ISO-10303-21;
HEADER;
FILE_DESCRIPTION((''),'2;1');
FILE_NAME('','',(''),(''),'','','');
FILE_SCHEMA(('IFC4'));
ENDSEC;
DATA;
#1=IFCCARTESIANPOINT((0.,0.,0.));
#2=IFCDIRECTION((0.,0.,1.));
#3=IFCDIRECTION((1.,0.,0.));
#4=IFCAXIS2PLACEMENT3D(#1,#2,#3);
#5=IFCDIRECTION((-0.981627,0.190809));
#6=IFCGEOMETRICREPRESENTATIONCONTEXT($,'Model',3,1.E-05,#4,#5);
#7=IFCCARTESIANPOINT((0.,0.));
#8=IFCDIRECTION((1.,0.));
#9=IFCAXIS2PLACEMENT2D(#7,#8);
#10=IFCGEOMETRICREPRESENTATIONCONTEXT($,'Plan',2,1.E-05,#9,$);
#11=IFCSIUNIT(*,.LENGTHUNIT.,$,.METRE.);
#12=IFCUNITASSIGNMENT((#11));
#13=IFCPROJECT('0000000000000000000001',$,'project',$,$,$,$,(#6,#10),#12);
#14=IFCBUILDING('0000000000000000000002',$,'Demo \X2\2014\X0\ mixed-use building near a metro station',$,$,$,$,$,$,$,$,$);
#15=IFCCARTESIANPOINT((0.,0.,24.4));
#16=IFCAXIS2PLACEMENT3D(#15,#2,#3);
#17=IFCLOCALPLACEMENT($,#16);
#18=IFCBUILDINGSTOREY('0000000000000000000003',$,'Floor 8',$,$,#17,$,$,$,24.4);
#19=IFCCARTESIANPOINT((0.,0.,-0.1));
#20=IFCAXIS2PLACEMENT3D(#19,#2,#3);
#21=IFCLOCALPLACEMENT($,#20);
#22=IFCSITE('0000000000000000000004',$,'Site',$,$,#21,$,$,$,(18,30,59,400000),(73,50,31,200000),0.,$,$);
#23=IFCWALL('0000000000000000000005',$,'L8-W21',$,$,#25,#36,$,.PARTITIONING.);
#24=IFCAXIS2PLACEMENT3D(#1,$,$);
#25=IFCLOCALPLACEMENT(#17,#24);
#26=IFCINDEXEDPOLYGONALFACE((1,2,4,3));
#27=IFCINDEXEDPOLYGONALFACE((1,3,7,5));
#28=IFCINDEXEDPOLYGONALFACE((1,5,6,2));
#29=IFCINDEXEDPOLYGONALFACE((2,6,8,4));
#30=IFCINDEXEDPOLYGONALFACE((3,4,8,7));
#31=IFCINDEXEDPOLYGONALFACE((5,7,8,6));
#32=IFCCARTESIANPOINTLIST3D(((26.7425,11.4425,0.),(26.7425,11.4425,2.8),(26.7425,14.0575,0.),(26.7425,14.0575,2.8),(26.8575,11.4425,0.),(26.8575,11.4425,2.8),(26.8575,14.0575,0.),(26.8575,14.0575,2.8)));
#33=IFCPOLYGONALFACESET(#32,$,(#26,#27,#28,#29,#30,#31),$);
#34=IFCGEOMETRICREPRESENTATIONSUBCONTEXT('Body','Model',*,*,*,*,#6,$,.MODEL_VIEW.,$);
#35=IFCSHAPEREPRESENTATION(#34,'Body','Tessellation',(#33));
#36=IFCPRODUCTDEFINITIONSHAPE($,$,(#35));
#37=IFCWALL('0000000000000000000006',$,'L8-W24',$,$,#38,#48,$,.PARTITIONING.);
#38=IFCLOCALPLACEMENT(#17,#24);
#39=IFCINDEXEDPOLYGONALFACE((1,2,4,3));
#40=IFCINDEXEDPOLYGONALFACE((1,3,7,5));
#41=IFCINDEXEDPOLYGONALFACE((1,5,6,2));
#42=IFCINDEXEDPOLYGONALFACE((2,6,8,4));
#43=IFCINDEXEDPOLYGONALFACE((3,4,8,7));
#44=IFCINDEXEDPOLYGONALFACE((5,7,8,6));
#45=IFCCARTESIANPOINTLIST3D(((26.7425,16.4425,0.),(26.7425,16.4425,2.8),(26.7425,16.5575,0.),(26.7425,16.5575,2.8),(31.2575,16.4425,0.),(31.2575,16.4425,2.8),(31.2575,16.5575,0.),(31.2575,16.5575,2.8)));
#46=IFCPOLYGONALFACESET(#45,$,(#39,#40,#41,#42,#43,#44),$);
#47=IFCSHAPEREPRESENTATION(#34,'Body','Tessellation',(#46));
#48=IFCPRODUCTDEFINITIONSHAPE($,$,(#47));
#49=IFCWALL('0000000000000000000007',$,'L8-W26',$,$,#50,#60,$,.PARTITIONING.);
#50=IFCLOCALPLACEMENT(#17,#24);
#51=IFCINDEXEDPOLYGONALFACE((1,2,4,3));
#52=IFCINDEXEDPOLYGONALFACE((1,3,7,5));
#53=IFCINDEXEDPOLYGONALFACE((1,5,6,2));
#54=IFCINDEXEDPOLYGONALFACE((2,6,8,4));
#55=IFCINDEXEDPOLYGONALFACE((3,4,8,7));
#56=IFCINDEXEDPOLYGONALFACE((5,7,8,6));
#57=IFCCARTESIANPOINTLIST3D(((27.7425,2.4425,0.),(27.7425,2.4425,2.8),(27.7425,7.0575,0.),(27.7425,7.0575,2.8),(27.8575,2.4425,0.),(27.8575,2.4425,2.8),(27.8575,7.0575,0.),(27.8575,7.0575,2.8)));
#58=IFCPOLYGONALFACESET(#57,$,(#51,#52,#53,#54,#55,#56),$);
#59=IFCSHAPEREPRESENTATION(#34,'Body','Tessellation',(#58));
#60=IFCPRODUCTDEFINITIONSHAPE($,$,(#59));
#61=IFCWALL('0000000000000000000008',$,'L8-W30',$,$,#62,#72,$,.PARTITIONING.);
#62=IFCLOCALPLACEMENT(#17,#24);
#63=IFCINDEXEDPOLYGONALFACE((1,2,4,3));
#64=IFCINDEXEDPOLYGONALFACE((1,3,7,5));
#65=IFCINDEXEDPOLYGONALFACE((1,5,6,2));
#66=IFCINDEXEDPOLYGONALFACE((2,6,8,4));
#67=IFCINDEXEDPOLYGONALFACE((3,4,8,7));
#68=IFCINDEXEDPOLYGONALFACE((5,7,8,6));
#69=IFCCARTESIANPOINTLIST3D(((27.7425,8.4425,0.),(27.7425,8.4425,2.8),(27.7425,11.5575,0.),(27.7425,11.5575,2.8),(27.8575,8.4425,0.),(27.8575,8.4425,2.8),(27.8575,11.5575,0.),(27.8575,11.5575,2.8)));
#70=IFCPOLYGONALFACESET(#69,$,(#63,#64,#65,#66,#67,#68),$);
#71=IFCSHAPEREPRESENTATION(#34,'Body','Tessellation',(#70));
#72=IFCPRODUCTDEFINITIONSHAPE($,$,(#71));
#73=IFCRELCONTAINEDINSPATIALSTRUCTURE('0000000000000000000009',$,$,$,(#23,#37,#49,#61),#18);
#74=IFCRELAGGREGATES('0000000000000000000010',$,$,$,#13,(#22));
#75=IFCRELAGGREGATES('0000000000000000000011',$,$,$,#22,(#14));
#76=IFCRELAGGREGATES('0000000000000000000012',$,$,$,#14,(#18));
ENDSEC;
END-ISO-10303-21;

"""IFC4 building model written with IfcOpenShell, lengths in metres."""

from ifc_helpers import new_model, si_unit, direction, frame, origin_with_axes, origin_2d_with_axis, place, context, subcontext, project, spatial, line, indexed_curve, outline, extrude, element, save


model = new_model("IFC4")

# Units and contexts
model_context = context("Model", 3, precision=1e-05, world=origin_with_axes(), true_north=direction((-0.981627, 0.190809)))
plan_context = context("Plan", 2, precision=1e-05, world=origin_2d_with_axis())
body_context = subcontext(model_context, "Body", "Model", "MODEL_VIEW")
ifc_project = project(units=[si_unit("LENGTHUNIT", "METRE")], contexts=[model_context, plan_context])

# Site, building, storey
site_placement = place(None, frame((0.0, 0.0, -0.1), z_axis=(0.0, 0.0, 1.0), x_axis=(1.0, 0.0, 0.0)))
site = spatial("IfcSite", under=ifc_project, at=site_placement, Name="Site", RefLatitude=(18, 30, 59, 400000), RefLongitude=(73, 50, 31, 200000), RefElevation=0.0)
building = spatial("IfcBuilding", under=site, Name="Demo — mixed-use building near a metro station")
storey_placement = place(None, frame((0.0, 0.0, 24.4), z_axis=(0.0, 0.0, 1.0), x_axis=(1.0, 0.0, 0.0)))
storey = spatial("IfcBuildingStorey", under=building, at=storey_placement, Name="Floor 8", Elevation=24.4)

# Wall
wall_1_placement = place(storey_placement, frame((0.0, 0.0, -24.4), z_axis=(0.0, 0.0, 1.0), x_axis=(1.0, 0.0, 0.0)))
element("IfcWall", 1, at=wall_1_placement, inside=storey, Name="L8-W21", PredefinedType="PARTITIONING", context=body_context, shape_type="SweptSolid", body=[
    extrude(outline(indexed_curve([(26.7425, 11.4425), (26.7425, 14.0575), (26.8575, 14.0575), (26.8575, 11.4425)], segments=[line(1, 2, 3, 4, 1)])), frame((0.0, 0.0, 24.4), z_axis=(0.0, 0.0, 1.0), x_axis=(1.0, 0.0, 0.0)), (0.0, 0.0, 1.0), 2.8),
])

# Wall
wall_2_placement = place(storey_placement, frame((0.0, 0.0, -24.4), z_axis=(0.0, 0.0, 1.0), x_axis=(1.0, 0.0, 0.0)))
element("IfcWall", 2, at=wall_2_placement, inside=storey, Name="L8-W24", PredefinedType="PARTITIONING", context=body_context, shape_type="SweptSolid", body=[
    extrude(outline(indexed_curve([(31.2575, 16.4425), (26.7425, 16.4425), (26.7425, 16.5575), (31.2575, 16.5575)], segments=[line(1, 2, 3, 4, 1)])), frame((0.0, 0.0, 24.4), z_axis=(0.0, 0.0, 1.0), x_axis=(1.0, 0.0, 0.0)), (0.0, 0.0, 1.0), 2.8),
])

# Wall
wall_3_placement = place(storey_placement, frame((0.0, 0.0, -24.4), z_axis=(0.0, 0.0, 1.0), x_axis=(1.0, 0.0, 0.0)))
element("IfcWall", 3, at=wall_3_placement, inside=storey, Name="L8-W26", PredefinedType="PARTITIONING", context=body_context, shape_type="SweptSolid", body=[
    extrude(outline(indexed_curve([(27.7425, 2.4425), (27.7425, 7.0575), (27.8575, 7.0575), (27.8575, 2.4425)], segments=[line(1, 2, 3, 4, 1)])), frame((0.0, 0.0, 24.4), z_axis=(0.0, 0.0, 1.0), x_axis=(1.0, 0.0, 0.0)), (0.0, 0.0, 1.0), 2.8),
])

# Wall
wall_4_placement = place(storey_placement, frame((0.0, 0.0, -24.4), z_axis=(0.0, 0.0, 1.0), x_axis=(1.0, 0.0, 0.0)))
element("IfcWall", 4, at=wall_4_placement, inside=storey, Name="L8-W30", PredefinedType="PARTITIONING", context=body_context, shape_type="SweptSolid", body=[
    extrude(outline(indexed_curve([(27.7425, 8.4425), (27.7425, 11.5575), (27.8575, 11.5575), (27.8575, 8.4425)], segments=[line(1, 2, 3, 4, 1)])), frame((0.0, 0.0, 24.4), z_axis=(0.0, 0.0, 1.0), x_axis=(1.0, 0.0, 0.0)), (0.0, 0.0, 1.0), 2.8),
])

save(model, "model.ifc")
